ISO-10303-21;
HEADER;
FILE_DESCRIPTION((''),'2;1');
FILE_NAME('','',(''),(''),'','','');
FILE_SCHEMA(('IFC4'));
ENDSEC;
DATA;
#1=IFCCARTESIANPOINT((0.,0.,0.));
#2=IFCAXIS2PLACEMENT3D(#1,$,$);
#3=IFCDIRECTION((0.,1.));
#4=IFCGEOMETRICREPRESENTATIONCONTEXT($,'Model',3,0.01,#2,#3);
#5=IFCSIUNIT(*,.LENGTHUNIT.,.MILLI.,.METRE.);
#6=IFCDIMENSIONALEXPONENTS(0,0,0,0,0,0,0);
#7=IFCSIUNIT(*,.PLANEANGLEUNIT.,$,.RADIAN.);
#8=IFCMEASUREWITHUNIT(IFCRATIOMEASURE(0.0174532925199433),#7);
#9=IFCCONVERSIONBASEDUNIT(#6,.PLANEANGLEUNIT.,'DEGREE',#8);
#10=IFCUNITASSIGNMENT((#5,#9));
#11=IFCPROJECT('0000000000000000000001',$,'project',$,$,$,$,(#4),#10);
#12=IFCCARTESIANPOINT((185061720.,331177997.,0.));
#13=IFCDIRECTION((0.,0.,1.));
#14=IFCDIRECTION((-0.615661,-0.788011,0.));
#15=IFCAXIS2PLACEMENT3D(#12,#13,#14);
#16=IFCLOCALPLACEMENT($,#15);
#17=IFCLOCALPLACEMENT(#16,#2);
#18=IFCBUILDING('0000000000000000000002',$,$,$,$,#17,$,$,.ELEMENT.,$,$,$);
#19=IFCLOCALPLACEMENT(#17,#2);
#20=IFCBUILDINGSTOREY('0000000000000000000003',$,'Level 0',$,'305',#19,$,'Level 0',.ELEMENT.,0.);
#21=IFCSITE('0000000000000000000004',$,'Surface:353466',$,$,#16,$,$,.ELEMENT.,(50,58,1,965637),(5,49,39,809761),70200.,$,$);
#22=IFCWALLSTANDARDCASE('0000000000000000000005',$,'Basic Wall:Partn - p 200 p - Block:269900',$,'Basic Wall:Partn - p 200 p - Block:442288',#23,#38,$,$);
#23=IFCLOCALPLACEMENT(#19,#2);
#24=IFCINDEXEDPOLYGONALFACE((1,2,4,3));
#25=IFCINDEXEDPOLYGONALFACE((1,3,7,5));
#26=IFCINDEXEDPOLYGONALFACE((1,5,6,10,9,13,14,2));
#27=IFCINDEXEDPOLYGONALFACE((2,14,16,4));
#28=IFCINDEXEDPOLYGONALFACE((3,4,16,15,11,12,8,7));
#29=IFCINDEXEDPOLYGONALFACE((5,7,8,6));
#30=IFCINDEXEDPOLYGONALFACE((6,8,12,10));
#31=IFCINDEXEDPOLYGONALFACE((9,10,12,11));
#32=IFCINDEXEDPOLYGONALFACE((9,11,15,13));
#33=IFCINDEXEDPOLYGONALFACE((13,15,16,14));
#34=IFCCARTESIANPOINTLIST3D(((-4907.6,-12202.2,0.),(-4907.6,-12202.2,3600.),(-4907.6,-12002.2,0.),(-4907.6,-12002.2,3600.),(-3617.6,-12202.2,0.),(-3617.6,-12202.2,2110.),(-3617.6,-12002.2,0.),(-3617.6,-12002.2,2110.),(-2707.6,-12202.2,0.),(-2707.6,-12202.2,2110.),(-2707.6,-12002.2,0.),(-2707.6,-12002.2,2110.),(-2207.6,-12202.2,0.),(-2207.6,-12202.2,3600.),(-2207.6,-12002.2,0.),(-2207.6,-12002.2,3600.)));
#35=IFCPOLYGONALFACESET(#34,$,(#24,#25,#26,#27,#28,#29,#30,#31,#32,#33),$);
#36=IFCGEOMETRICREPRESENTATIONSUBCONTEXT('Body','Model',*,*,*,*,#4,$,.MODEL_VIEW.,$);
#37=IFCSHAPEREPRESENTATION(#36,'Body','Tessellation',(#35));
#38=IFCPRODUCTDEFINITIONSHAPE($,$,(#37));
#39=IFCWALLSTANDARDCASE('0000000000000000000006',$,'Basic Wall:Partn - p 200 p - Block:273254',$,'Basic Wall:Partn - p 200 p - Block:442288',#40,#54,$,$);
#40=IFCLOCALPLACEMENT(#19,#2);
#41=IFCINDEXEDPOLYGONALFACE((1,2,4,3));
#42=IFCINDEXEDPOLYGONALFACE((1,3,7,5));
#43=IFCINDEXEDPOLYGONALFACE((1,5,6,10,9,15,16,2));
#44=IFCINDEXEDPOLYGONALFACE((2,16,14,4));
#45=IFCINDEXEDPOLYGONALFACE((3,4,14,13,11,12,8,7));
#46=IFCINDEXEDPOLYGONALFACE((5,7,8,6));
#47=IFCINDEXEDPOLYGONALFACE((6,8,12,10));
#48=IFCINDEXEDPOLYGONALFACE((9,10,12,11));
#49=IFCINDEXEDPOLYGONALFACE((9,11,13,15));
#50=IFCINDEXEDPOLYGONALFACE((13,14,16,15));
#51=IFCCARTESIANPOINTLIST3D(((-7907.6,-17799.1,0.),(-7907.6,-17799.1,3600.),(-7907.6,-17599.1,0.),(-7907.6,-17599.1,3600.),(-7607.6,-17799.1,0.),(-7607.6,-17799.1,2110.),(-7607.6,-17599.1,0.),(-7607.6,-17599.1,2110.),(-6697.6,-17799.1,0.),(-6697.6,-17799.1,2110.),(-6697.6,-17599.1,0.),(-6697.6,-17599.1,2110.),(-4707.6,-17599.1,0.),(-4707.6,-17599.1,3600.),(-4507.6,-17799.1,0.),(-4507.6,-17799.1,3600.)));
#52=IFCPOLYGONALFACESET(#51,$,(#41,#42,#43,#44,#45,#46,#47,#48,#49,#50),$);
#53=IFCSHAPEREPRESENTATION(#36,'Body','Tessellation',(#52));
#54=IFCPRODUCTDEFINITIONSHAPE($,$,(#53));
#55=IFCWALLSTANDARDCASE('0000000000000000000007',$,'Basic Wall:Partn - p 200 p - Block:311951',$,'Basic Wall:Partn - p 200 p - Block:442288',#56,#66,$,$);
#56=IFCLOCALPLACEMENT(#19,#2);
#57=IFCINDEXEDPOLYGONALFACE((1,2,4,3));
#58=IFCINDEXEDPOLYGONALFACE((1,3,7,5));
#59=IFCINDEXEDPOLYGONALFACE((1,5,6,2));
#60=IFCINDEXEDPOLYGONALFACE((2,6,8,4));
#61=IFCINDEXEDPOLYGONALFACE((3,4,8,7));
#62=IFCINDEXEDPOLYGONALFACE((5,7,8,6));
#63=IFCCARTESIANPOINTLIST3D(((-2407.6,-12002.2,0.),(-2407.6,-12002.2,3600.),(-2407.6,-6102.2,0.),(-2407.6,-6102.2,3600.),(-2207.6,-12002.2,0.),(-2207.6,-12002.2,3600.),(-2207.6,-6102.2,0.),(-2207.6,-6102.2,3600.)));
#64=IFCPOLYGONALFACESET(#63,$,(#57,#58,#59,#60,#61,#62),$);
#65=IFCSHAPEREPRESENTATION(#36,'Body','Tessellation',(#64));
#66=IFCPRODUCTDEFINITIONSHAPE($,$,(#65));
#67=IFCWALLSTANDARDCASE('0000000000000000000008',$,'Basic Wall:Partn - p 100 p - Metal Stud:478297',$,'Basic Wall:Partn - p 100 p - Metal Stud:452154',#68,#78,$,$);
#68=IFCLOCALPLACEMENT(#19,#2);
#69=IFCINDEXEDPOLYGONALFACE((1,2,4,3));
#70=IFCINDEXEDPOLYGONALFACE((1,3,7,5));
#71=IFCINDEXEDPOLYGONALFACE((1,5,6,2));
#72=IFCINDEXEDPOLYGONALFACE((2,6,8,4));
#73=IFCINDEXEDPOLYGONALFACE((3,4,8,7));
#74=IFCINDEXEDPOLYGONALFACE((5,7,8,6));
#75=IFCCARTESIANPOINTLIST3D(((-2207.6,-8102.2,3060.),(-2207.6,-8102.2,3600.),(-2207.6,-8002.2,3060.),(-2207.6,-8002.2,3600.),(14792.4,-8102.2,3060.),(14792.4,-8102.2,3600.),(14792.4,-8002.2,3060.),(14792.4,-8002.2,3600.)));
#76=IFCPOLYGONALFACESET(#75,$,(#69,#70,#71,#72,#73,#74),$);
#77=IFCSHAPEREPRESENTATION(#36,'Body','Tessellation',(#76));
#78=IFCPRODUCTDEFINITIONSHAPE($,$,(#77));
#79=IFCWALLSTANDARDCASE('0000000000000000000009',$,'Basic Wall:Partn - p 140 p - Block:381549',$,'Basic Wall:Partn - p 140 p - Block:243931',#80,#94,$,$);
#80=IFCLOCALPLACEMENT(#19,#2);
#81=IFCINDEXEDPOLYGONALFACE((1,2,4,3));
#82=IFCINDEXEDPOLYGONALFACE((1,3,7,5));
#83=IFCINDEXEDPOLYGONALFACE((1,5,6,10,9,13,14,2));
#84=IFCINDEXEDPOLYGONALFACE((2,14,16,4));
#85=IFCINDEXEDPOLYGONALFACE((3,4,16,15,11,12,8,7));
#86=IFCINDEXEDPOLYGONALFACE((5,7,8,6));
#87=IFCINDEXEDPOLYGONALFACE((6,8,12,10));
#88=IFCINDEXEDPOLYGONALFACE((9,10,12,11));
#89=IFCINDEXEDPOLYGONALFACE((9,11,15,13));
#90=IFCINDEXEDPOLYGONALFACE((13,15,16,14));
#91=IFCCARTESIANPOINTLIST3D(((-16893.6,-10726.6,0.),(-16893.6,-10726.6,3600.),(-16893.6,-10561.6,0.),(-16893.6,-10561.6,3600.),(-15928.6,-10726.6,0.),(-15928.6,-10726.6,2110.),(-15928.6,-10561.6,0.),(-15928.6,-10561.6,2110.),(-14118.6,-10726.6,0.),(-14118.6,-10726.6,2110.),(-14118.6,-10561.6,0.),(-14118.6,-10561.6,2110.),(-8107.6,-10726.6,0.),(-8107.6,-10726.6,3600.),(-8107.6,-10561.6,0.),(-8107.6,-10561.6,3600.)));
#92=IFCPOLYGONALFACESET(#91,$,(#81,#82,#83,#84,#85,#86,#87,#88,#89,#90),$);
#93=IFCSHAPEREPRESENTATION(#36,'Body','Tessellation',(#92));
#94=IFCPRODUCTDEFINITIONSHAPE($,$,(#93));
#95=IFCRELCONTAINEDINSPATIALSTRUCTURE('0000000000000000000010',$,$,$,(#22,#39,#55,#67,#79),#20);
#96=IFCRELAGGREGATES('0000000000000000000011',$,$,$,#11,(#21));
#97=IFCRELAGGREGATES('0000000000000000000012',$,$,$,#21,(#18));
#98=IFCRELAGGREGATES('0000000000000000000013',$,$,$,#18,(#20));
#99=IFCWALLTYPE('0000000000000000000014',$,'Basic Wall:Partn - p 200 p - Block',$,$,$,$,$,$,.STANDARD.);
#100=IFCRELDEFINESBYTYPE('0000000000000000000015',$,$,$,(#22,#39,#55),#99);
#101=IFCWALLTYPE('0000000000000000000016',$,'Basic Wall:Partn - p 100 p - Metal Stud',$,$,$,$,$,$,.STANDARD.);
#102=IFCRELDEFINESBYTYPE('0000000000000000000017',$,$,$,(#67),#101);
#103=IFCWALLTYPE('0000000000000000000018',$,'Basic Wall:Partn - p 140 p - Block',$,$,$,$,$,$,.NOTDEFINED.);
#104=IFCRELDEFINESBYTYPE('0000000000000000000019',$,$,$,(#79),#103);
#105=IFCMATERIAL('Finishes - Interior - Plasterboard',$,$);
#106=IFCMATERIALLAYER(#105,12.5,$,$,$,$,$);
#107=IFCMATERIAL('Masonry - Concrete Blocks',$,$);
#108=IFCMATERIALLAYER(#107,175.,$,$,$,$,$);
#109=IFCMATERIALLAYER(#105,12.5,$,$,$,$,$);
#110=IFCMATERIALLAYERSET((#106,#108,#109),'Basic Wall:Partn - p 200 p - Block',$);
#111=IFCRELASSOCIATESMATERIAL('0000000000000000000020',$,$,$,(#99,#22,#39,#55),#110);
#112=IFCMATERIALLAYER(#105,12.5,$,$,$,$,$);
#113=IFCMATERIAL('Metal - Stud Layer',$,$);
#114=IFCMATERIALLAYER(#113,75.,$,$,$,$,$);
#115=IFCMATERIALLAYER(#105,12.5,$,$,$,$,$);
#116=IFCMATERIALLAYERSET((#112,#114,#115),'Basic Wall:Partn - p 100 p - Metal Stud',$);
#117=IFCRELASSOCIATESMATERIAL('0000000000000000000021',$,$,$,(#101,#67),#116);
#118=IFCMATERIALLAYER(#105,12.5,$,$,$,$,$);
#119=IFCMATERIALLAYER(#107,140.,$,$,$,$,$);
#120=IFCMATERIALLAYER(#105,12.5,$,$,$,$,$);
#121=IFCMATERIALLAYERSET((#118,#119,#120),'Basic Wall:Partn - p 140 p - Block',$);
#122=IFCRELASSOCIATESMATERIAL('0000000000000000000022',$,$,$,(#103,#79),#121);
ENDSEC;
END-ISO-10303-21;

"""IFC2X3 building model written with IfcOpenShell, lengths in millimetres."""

from ifc_helpers import new_model, entity, si_unit, converted_unit, direction, frame, frame_2d, origin, place, context, subcontext, project, spatial, polyline, rectangle, outline, extrude, clip, bounded_halfspace, material, layer, layer_set, layer_usage, type_object, element, save


model = new_model("IFC2X3")

# Units and contexts
model_context = context("Model", 3, precision=0.01, world=origin(), true_north=direction((0.0, 1.0)))
body_context = subcontext(model_context, "Body", "Model", "MODEL_VIEW")
ifc_project = project(units=[si_unit("LENGTHUNIT", "METRE", prefix="MILLI"), converted_unit("PLANEANGLEUNIT", "DEGREE", entity("IfcRatioMeasure", 0.0174532925199433), si_unit("PLANEANGLEUNIT", "RADIAN"), dimensions=[0, 0, 0, 0, 0, 0, 0])], contexts=[model_context])

# Site, building, storey
site_placement = place(None, frame((185061720.0, 331177997.0, 0.0), z_axis=(0.0, 0.0, 1.0), x_axis=(-0.615661, -0.788011, 0.0)))
site = spatial("IfcSite", under=ifc_project, at=site_placement, Name="Surface:353466", CompositionType="ELEMENT", RefLatitude=(50, 58, 1, 965637), RefLongitude=(5, 49, 39, 809761), RefElevation=70200.0)
building_placement = place(site_placement, origin())
building = spatial("IfcBuilding", under=site, at=building_placement, CompositionType="ELEMENT")
storey_placement = place(building_placement, origin())
storey = spatial("IfcBuildingStorey", under=building, at=storey_placement, Name="Level 0", ObjectType="305", LongName="Level 0", CompositionType="ELEMENT", Elevation=0.0)

# Shared definitions
ifc_material_1 = material(Name="Masonry - Concrete Blocks")
ifc_material_2 = material(Name="Finishes - Interior - Plasterboard")

# Shared definitions
ifc_layer_1 = layer(ifc_material_2, 12.5)
ifc_layer_2 = layer(ifc_material_1, 175.0)
ifc_layer_3 = layer(ifc_material_2, 12.5)
ifc_layer_set_1 = layer_set([ifc_layer_1, ifc_layer_2, ifc_layer_3], Name="Basic Wall:Partn - p 200 p - Block")
wall_type_1 = type_object("IfcWallType", Name="Basic Wall:Partn - p 200 p - Block", PredefinedType="STANDARD", material=ifc_layer_set_1)

# Walls, openings
ifc_layer_usage_1 = layer_usage(ifc_layer_set_1, "AXIS2", "POSITIVE", -100.0)
wall_1_placement = place(storey_placement, frame((-4907.6, -12102.2, 0.0)))
wall_1 = element("IfcWallStandardCase", 1, at=wall_1_placement, inside=storey, type_object=wall_type_1, material=ifc_layer_usage_1, Name="Basic Wall:Partn - p 200 p - Block:269900", ObjectType="Basic Wall:Partn - p 200 p - Block:442288", context=body_context, shape_type="Clipping", body=[
    clip(extrude(rectangle(XDim=2700.0, YDim=200.0, at=frame_2d((1350.0, 0.0), x_axis=(-1.0, 0.0))), origin(), (0.0, 0.0, 1.0), 3600.0), bounded_halfspace(frame((0.0, -100.0, 3600.0), z_axis=(0.0, 0.0, -1.0), x_axis=(1.0, 0.0, 0.0)), True, frame((0.0, -100.0, 3600.0)), polyline([(0.0, 0.0), (200.0, 0.0), (400.0, 0.0), (2700.0, 0.0), (2700.0, 200.0), (2500.0, 200.0), (0.0, 200.0), (0.0, 0.0)]))),
])
opening_1_placement = place(wall_1_placement, origin())
element("IfcOpeningElement", 2, at=opening_1_placement, cuts=wall_1, ObjectType="Opening", context=body_context, shape_type="SweptSolid", body=[
    extrude(rectangle(XDim=2110.0, YDim=910.0, at=frame_2d((0.0, 0.0), x_axis=(0.0, 1.0))), frame((1745.0, -1624.0, 1055.0), z_axis=(0.0, 1.0, 0.0), x_axis=(-1.0, 0.0, 0.0)), (0.0, 0.0, 1.0), 3048.0),
])
opening_2_placement = place(wall_1_placement, frame((1290.0, -100.0, 0.0)))
element("IfcOpeningElement", 3, at=opening_2_placement, cuts=wall_1, ObjectType="Opening", context=body_context, shape_type="SweptSolid", body=[
    extrude(rectangle(XDim=2110.0, YDim=910.0, at=frame_2d((1055.0, 455.0), x_axis=(1.0, 0.0))), frame((0.0, 0.0, 0.0), z_axis=(0.0, 1.0, 0.0), x_axis=(0.0, 0.0, 1.0)), (0.0, 0.0, 1.0), 200.0),
])
ifc_layer_usage_2 = layer_usage(ifc_layer_set_1, "AXIS2", "NEGATIVE", 100.0)
wall_2_placement = place(storey_placement, frame((-4507.6, -17699.1, 0.0), z_axis=(0.0, 0.0, 1.0), x_axis=(-1.0, 0.0, 0.0)))
wall_2 = element("IfcWallStandardCase", 4, at=wall_2_placement, inside=storey, type_object=wall_type_1, material=ifc_layer_usage_2, Name="Basic Wall:Partn - p 200 p - Block:273254", ObjectType="Basic Wall:Partn - p 200 p - Block:442288", context=body_context, shape_type="Clipping", body=[
    clip(extrude(outline(polyline([(200.0, -100.0), (3400.0, -100.0), (3400.0, 100.0), (0.0, 100.0), (200.0, -100.0)])), origin(), (0.0, 0.0, 1.0), 3600.0), bounded_halfspace(frame((200.0, -100.0, 3600.0), z_axis=(0.0, 0.0, -1.0), x_axis=(-1.0, 0.0, 0.0)), True, frame((200.0, -100.0, 3600.0)), polyline([(0.0, 0.0), (3200.0, 0.0), (3200.0, 200.0), (-200.0, 200.0), (0.0, 0.0)]))),
])
opening_3_placement = place(wall_2_placement, origin())
element("IfcOpeningElement", 5, at=opening_3_placement, cuts=wall_2, ObjectType="Opening", context=body_context, shape_type="SweptSolid", body=[
    extrude(rectangle(XDim=2110.0, YDim=910.0, at=frame_2d((0.0, 0.0), x_axis=(0.0, 1.0))), frame((2645.0, -1424.0, 1055.0), z_axis=(0.0, 1.0, 0.0), x_axis=(-1.0, 0.0, 0.0)), (0.0, 0.0, 1.0), 3048.0),
])
opening_4_placement = place(wall_2_placement, frame((3100.0, 100.0, 0.0)))
element("IfcOpeningElement", 6, at=opening_4_placement, cuts=wall_2, ObjectType="Opening", context=body_context, shape_type="SweptSolid", body=[
    extrude(rectangle(XDim=2110.0, YDim=910.0, at=frame_2d((1055.0, 455.0), x_axis=(1.0, 0.0))), frame((0.0, 0.0, 0.0), z_axis=(0.0, -1.0, 0.0), x_axis=(0.0, 0.0, 1.0)), (0.0, 0.0, 1.0), 200.0),
])

# Wall
ifc_layer_usage_3 = layer_usage(ifc_layer_set_1, "AXIS2", "NEGATIVE", 100.0)
wall_3_placement = place(storey_placement, frame((-2307.6, -6102.2, 0.0), z_axis=(0.0, 0.0, 1.0), x_axis=(0.0, -1.0, 0.0)))
element("IfcWallStandardCase", 7, at=wall_3_placement, inside=storey, type_object=wall_type_1, material=ifc_layer_usage_3, Name="Basic Wall:Partn - p 200 p - Block:311951", ObjectType="Basic Wall:Partn - p 200 p - Block:442288", context=body_context, shape_type="Clipping", body=[
    clip(extrude(rectangle(XDim=5900.0, YDim=200.0, at=frame_2d((2950.0, 0.0), x_axis=(-1.0, 0.0))), origin(), (0.0, 0.0, 1.0), 3600.0), bounded_halfspace(frame((0.0, -100.0, 3600.0), z_axis=(0.0, 0.0, -1.0), x_axis=(0.0, 1.0, 0.0)), True, frame((0.0, -100.0, 3600.0)), polyline([(0.0, 0.0), (5900.0, 0.0), (5900.0, 200.0), (0.0, 200.0), (0.0, 0.0)]))),
])

# Wall
ifc_layer_4 = layer(ifc_material_2, 12.5)
ifc_material_3 = material(Name="Metal - Stud Layer")
ifc_layer_5 = layer(ifc_material_3, 75.0)
ifc_layer_6 = layer(ifc_material_2, 12.5)
ifc_layer_set_2 = layer_set([ifc_layer_4, ifc_layer_5, ifc_layer_6], Name="Basic Wall:Partn - p 100 p - Metal Stud")
ifc_layer_usage_4 = layer_usage(ifc_layer_set_2, "AXIS2", "NEGATIVE", 50.0)
wall_type_2 = type_object("IfcWallType", Name="Basic Wall:Partn - p 100 p - Metal Stud", PredefinedType="STANDARD", material=ifc_layer_set_2)
wall_4_placement = place(storey_placement, frame((-2207.6, -8052.2, 3060.0)))
element("IfcWallStandardCase", 8, at=wall_4_placement, inside=storey, type_object=wall_type_2, material=ifc_layer_usage_4, Name="Basic Wall:Partn - p 100 p - Metal Stud:478297", ObjectType="Basic Wall:Partn - p 100 p - Metal Stud:452154", context=body_context, shape_type="SweptSolid", body=[
    extrude(rectangle(XDim=17000.0, YDim=100.0, at=frame_2d((8500.0, 0.0), x_axis=(-1.0, 0.0))), origin(), (0.0, 0.0, 1.0), 540.0),
])

# Wall, openings
ifc_layer_7 = layer(ifc_material_2, 12.5)
ifc_layer_8 = layer(ifc_material_1, 140.0)
ifc_layer_9 = layer(ifc_material_2, 12.5)
ifc_layer_set_3 = layer_set([ifc_layer_7, ifc_layer_8, ifc_layer_9], Name="Basic Wall:Partn - p 140 p - Block")
ifc_layer_usage_5 = layer_usage(ifc_layer_set_3, "AXIS2", "POSITIVE", -82.5)
wall_type_3 = type_object("IfcWallType", Name="Basic Wall:Partn - p 140 p - Block", PredefinedType="NOTDEFINED", material=ifc_layer_set_3)
wall_5_placement = place(storey_placement, frame((-8107.6, -10644.1, 0.0), z_axis=(0.0, 0.0, 1.0), x_axis=(-1.0, 0.0, 0.0)))
wall_5 = element("IfcWallStandardCase", 9, at=wall_5_placement, inside=storey, type_object=wall_type_3, material=ifc_layer_usage_5, Name="Basic Wall:Partn - p 140 p - Block:381549", ObjectType="Basic Wall:Partn - p 140 p - Block:243931", context=body_context, shape_type="Clipping", body=[
    clip(extrude(rectangle(XDim=8786.0, YDim=165.0, at=frame_2d((4393.0, 0.0), x_axis=(-1.0, 0.0))), origin(), (0.0, 0.0, 1.0), 3600.0), bounded_halfspace(frame((0.0, -82.5, 3600.0), z_axis=(0.0, 0.0, -1.0), x_axis=(0.0, 1.0, 0.0)), True, frame((0.0, -82.5, 3600.0)), polyline([(0.0, 0.0), (8621.0, 0.0), (8786.0, 0.0), (8786.0, 165.0), (0.0, 165.0), (0.0, 0.0)]))),
])
opening_5_placement = place(wall_5_placement, origin())
element("IfcOpeningElement", 10, at=opening_5_placement, cuts=wall_5, ObjectType="Opening", context=body_context, shape_type="SweptSolid", body=[
    extrude(rectangle(XDim=2110.0, YDim=1810.0, at=frame_2d((0.0, 0.0), x_axis=(1.0, 0.0))), frame((6916.0, -1441.5, 1055.0), z_axis=(0.0, 1.0, 0.0), x_axis=(0.0, 0.0, 1.0)), (0.0, 0.0, 1.0), 3048.0),
])
opening_6_placement = place(wall_5_placement, frame((7821.0, 82.5, 0.0)))
element("IfcOpeningElement", 11, at=opening_6_placement, cuts=wall_5, ObjectType="Opening", context=body_context, shape_type="SweptSolid", body=[
    extrude(rectangle(XDim=2110.0, YDim=1810.0, at=frame_2d((1055.0, 905.0), x_axis=(1.0, 0.0))), frame((0.0, 0.0, 0.0), z_axis=(0.0, -1.0, 0.0), x_axis=(0.0, 0.0, 1.0)), (0.0, 0.0, 1.0), 165.0),
])

save(model, "model.ifc")
